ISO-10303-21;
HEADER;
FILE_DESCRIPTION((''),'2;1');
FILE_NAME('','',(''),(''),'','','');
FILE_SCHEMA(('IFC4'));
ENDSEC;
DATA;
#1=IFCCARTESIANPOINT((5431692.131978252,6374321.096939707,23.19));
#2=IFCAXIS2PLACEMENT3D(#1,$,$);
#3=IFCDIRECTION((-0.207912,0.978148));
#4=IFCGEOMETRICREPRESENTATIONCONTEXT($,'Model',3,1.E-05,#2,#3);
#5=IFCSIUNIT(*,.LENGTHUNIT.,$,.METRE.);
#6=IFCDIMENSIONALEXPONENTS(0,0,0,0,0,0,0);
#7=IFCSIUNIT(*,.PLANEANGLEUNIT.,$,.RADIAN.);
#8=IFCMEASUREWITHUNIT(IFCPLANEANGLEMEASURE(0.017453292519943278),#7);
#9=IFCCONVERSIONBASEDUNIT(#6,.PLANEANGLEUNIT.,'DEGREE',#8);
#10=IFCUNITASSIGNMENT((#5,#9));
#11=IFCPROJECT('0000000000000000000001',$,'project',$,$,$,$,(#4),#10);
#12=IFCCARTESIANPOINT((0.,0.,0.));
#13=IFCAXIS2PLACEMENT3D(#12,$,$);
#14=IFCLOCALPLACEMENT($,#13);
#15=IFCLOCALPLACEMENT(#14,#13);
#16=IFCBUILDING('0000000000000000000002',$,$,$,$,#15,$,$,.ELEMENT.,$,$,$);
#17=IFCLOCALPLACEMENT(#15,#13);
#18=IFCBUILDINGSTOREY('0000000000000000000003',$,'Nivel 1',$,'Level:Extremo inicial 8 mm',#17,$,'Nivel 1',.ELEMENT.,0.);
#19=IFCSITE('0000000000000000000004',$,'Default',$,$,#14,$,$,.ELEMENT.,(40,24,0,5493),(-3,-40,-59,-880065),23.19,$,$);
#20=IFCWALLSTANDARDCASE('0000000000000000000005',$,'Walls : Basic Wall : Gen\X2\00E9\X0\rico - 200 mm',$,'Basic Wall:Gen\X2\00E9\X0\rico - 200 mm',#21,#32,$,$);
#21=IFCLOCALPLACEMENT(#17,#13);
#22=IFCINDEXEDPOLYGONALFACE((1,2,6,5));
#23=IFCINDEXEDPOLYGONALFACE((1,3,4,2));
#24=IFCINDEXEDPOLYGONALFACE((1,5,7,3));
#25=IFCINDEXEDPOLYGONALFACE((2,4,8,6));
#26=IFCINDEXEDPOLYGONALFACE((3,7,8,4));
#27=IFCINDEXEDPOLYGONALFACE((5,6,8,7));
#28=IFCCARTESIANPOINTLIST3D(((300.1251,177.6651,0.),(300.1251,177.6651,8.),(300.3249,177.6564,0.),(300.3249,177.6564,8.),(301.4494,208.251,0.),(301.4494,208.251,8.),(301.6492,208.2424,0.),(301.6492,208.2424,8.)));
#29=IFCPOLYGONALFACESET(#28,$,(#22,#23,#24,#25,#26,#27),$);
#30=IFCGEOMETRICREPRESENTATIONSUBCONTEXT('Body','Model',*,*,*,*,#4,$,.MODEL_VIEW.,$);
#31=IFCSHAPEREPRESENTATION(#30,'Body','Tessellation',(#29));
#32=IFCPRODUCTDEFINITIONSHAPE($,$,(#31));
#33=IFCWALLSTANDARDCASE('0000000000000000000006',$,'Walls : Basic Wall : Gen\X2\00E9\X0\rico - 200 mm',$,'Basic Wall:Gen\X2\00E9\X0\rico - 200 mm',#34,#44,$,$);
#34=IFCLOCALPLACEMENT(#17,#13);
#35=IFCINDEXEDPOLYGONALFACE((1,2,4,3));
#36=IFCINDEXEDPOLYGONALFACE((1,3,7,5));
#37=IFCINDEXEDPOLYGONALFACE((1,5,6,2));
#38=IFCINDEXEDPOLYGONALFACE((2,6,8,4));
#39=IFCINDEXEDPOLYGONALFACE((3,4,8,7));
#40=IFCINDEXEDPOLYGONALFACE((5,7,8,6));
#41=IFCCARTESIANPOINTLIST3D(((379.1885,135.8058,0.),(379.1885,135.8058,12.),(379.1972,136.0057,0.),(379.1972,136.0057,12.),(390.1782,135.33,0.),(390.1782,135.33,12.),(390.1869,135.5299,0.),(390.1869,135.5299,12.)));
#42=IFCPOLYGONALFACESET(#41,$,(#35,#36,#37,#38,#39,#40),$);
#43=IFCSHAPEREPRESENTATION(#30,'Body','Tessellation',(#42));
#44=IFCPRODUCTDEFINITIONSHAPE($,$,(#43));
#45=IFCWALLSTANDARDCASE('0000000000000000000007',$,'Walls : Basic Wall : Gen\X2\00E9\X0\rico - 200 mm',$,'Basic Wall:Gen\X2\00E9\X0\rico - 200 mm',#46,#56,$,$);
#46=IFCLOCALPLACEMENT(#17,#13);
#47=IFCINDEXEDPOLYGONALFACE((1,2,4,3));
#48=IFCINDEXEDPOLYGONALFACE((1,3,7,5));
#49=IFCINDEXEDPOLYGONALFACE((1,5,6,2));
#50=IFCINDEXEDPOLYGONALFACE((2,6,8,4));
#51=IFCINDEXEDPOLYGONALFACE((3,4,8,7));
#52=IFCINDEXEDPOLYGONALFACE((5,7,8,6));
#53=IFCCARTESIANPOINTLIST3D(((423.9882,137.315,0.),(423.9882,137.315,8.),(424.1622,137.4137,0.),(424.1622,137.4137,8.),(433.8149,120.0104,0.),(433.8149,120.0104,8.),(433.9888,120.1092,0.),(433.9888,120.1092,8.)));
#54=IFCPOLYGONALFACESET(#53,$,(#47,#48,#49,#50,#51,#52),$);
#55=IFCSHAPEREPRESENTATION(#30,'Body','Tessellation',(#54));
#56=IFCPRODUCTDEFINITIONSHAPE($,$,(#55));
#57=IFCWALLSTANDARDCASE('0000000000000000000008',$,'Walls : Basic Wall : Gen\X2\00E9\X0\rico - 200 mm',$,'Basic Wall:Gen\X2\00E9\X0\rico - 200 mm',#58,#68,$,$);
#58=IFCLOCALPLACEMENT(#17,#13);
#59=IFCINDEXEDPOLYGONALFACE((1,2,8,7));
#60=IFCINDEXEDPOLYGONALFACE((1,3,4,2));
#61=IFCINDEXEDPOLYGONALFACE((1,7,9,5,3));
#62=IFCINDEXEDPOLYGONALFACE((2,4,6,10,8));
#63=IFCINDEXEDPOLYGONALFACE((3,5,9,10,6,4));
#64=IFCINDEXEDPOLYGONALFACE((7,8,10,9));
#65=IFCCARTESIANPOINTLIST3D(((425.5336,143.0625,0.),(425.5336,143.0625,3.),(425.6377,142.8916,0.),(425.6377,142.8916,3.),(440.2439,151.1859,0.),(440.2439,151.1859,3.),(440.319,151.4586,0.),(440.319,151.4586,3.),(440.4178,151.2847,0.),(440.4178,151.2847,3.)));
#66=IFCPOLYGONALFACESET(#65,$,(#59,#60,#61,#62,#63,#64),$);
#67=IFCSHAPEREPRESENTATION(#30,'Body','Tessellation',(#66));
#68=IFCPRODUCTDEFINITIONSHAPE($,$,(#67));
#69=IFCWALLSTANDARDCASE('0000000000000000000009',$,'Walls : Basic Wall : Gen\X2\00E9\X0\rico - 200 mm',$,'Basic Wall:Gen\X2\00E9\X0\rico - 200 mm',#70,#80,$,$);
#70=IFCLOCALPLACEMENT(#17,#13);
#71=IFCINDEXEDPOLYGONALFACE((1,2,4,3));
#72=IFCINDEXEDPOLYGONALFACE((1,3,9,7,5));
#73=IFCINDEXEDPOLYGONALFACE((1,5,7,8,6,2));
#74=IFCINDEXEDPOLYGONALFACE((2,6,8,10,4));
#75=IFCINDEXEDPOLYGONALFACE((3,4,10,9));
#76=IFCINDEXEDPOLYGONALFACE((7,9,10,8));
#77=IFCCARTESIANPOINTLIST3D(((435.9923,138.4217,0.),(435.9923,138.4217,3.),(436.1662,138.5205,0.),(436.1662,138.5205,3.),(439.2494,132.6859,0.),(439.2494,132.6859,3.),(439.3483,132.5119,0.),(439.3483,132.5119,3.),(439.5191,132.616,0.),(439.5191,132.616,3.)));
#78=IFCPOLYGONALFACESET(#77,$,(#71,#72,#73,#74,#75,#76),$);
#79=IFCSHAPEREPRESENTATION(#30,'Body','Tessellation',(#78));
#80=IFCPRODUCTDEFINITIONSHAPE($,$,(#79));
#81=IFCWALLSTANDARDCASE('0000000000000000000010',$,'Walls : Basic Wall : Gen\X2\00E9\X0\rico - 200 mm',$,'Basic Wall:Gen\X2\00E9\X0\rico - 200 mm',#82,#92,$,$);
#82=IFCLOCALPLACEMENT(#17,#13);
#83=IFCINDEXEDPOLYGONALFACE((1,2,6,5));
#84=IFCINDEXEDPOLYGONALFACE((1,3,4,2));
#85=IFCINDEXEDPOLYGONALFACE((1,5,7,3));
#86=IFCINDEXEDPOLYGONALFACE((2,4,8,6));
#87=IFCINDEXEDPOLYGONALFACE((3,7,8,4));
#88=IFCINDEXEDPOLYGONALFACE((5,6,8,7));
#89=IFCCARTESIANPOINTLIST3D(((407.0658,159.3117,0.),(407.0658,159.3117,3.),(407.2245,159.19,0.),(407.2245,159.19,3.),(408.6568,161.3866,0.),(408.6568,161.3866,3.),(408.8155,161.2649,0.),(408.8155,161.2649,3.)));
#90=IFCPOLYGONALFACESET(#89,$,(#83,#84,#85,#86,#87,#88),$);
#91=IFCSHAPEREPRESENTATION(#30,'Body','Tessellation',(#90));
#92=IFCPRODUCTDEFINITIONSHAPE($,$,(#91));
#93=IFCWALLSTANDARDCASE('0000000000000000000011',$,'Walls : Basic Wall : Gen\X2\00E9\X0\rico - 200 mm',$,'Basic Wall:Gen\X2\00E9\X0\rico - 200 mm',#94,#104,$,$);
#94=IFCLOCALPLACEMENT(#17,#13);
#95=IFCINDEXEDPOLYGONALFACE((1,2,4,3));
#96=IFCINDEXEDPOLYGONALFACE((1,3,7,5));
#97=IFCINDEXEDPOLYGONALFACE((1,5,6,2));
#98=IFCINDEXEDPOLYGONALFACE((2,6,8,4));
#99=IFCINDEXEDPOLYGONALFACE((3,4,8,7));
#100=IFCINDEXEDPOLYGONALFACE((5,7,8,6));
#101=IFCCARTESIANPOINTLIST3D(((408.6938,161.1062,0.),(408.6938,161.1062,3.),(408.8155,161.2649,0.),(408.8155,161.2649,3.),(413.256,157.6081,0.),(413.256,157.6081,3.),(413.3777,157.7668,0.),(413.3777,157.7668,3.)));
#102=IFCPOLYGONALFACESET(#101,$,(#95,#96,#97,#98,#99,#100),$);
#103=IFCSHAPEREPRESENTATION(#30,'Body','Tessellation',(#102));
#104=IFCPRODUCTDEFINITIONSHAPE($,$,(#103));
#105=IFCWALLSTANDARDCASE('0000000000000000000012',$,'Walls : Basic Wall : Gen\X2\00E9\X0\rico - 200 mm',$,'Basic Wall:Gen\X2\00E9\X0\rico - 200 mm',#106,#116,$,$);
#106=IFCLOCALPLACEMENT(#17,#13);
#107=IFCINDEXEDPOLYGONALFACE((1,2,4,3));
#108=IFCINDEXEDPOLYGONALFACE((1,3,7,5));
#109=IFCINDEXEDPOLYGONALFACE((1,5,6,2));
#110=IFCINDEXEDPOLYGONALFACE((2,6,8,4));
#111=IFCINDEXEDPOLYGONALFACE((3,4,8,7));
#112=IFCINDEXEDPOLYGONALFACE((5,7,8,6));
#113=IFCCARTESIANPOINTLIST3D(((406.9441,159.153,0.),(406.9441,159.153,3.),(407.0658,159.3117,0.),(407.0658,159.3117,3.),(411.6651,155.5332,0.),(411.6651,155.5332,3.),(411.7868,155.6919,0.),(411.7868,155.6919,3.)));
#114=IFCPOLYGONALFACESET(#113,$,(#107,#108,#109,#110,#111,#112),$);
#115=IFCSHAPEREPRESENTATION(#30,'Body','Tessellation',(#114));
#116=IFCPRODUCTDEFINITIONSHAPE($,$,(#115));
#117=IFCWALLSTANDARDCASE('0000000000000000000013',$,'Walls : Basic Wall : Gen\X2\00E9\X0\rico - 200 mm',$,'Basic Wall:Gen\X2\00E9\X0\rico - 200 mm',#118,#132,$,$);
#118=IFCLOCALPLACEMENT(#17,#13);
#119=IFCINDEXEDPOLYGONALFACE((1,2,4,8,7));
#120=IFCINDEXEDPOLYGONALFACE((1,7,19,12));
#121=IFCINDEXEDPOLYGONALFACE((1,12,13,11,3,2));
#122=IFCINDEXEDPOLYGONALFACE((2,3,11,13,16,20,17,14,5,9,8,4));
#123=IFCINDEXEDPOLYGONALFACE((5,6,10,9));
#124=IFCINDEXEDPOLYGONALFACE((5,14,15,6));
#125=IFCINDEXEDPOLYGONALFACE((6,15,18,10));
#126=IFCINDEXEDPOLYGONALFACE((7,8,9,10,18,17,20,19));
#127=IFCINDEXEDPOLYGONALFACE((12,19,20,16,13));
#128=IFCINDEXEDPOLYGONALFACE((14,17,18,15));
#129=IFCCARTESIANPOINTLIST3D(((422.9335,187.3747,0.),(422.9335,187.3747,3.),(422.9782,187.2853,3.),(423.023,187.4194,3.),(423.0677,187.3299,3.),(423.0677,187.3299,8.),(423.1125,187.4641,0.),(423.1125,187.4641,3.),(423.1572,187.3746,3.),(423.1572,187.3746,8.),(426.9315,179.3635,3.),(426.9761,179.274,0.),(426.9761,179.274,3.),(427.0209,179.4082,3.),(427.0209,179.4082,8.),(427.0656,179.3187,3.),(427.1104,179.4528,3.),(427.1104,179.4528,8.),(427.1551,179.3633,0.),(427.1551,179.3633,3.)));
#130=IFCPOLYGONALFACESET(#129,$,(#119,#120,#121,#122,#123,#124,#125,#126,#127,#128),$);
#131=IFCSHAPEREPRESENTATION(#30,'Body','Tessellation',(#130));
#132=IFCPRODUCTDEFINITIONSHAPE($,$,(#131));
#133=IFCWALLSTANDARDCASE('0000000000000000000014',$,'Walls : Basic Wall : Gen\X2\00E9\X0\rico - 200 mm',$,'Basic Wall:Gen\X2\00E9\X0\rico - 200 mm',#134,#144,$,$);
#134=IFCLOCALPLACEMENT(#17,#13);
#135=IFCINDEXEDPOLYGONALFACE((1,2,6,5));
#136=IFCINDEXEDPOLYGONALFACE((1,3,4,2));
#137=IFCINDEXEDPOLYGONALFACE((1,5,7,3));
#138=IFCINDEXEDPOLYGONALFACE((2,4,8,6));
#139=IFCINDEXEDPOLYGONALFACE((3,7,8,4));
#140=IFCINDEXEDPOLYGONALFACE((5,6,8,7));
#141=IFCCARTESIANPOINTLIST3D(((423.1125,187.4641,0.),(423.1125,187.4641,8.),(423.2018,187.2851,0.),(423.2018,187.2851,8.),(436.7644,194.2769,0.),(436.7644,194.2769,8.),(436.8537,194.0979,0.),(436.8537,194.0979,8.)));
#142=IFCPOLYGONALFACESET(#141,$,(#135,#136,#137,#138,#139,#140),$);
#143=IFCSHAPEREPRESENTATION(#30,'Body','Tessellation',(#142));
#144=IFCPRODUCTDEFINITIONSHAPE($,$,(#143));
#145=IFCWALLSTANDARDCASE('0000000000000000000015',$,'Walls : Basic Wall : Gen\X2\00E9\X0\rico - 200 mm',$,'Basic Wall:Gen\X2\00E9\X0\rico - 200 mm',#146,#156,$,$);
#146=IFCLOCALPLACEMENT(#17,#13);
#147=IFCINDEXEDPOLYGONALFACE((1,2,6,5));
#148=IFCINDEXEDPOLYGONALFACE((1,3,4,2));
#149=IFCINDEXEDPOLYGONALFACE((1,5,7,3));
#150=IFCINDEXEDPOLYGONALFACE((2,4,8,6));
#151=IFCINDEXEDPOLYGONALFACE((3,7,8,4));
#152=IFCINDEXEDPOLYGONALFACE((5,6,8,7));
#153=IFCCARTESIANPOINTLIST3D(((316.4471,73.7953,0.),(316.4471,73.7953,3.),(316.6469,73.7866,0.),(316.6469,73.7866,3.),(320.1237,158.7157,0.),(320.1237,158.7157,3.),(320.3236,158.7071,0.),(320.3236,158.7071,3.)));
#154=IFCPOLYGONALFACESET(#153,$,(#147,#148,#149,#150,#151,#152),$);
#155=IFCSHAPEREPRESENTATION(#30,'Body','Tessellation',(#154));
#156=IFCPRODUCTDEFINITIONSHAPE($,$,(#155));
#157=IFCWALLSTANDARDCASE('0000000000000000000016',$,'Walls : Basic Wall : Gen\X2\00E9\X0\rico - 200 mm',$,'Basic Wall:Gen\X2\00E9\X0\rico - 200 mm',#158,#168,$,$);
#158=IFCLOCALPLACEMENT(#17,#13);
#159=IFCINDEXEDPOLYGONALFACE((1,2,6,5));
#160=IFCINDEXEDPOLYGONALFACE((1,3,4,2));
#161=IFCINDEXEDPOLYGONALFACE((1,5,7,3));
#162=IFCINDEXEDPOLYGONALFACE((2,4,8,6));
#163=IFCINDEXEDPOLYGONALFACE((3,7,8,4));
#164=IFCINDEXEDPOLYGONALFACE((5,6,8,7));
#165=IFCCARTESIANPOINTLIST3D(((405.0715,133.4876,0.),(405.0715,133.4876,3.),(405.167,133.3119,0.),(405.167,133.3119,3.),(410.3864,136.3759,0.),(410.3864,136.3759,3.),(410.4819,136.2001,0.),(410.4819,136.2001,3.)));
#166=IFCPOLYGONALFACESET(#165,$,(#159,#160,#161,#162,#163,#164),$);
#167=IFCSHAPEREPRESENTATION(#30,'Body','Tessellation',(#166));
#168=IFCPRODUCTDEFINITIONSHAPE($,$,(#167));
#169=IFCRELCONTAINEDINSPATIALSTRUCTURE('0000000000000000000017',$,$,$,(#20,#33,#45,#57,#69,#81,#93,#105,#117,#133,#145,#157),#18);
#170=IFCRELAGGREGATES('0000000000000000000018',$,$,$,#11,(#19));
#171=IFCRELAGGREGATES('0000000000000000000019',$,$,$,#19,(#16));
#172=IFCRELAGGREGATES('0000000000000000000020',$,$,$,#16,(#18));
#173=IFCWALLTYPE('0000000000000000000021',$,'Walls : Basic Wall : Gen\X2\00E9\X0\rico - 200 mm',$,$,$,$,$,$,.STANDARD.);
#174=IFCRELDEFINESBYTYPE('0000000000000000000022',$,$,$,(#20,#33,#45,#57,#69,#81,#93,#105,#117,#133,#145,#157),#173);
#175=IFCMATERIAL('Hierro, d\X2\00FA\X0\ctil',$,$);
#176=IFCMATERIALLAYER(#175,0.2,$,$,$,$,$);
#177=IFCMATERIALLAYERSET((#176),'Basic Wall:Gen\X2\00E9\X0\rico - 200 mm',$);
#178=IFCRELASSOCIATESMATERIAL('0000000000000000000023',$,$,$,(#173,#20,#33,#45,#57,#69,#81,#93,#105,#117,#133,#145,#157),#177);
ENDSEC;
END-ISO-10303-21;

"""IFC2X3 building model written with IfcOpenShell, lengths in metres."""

from ifc_helpers import new_model, entity, si_unit, converted_unit, direction, frame, frame_2d, origin, place, context, subcontext, project, spatial, polyline, rectangle, outline, extrude, clip, bounded_halfspace, material, layer, layer_set, layer_usage, type_object, element, save


model = new_model("IFC2X3")

# Units and contexts
model_context = context("Model", 3, precision=1e-05, world=frame((5431692.131978252, 6374321.096939707, 23.19)), true_north=direction((-0.207912, 0.978148)))
body_context = subcontext(model_context, "Body", "Model", "MODEL_VIEW")
ifc_project = project(units=[si_unit("LENGTHUNIT", "METRE"), converted_unit("PLANEANGLEUNIT", "DEGREE", entity("IfcPlaneAngleMeasure", 0.017453292519943278), si_unit("PLANEANGLEUNIT", "RADIAN"), dimensions=[0, 0, 0, 0, 0, 0, 0])], contexts=[model_context])

# Site, building, storey
site_placement = place(None, origin())
site = spatial("IfcSite", under=ifc_project, at=site_placement, Name="Default", CompositionType="ELEMENT", RefLatitude=(40, 24, 0, 5493), RefLongitude=(-3, -40, -59, -880065), RefElevation=23.19)
building_placement = place(site_placement, origin())
building = spatial("IfcBuilding", under=site, at=building_placement, CompositionType="ELEMENT")
storey_placement = place(building_placement, origin())
storey = spatial("IfcBuildingStorey", under=building, at=storey_placement, Name="Nivel 1", ObjectType="Level:Extremo inicial 8 mm", LongName="Nivel 1", CompositionType="ELEMENT", Elevation=0.0)

# Walls
ifc_material_1 = material(Name="Hierro, dúctil")
ifc_layer_1 = layer(ifc_material_1, 0.2)
ifc_layer_set_1 = layer_set([ifc_layer_1], Name="Basic Wall:Genérico - 200 mm")
wall_type = type_object("IfcWallType", Name="Walls : Basic Wall : Genérico - 200 mm", PredefinedType="STANDARD", material=ifc_layer_set_1)
ifc_layer_usage_1 = layer_usage(ifc_layer_set_1, "AXIS2", "NEGATIVE", 0.1)
wall_1_placement = place(storey_placement, frame((300.225, 177.6607, 0.0), z_axis=(0.0, 0.0, 1.0), x_axis=(0.043255, 0.999064, 0.0)))
element("IfcWallStandardCase", 1, at=wall_1_placement, inside=storey, type_object=wall_type, material=ifc_layer_usage_1, Name="Walls : Basic Wall : Genérico - 200 mm", ObjectType="Basic Wall:Genérico - 200 mm", context=body_context, shape_type="SweptSolid", body=[
    extrude(rectangle(XDim=30.6146, YDim=0.2, at=frame_2d((15.3073, 0.0), x_axis=(-1.0, 0.0))), origin(), (0.0, 0.0, 1.0), 8.0),
])
ifc_layer_usage_2 = layer_usage(ifc_layer_set_1, "AXIS2", "NEGATIVE", 0.1)
wall_2_placement = place(storey_placement, frame((390.1826, 135.4299, 0.0), z_axis=(0.0, 0.0, 1.0), x_axis=(-0.999064, 0.043255, 0.0)))
element("IfcWallStandardCase", 2, at=wall_2_placement, inside=storey, type_object=wall_type, material=ifc_layer_usage_2, Name="Walls : Basic Wall : Genérico - 200 mm", ObjectType="Basic Wall:Genérico - 200 mm", context=body_context, shape_type="Clipping", body=[
    clip(extrude(rectangle(XDim=11.0, YDim=0.2, at=frame_2d((5.5, 0.0), x_axis=(-1.0, 0.0))), origin(), (0.0, 0.0, 1.0), 12.0), bounded_halfspace(frame((0.0, -0.1, 12.0), z_axis=(0.0, 0.0, 1.0), x_axis=(-0.999064, -0.043255, 0.0)), False, frame((0.0, -0.1, 12.0)), polyline([(0.0, 0.0), (11.0, 0.0), (11.0, 0.2), (0.0, 0.2), (0.0, 0.0)]))),
])
ifc_layer_usage_3 = layer_usage(ifc_layer_set_1, "AXIS2", "NEGATIVE", 0.1)
wall_3_placement = place(storey_placement, frame((424.0752, 137.3644, 0.0), z_axis=(0.0, 0.0, 1.0), x_axis=(0.4938, -0.869576, 0.0)))
element("IfcWallStandardCase", 3, at=wall_3_placement, inside=storey, type_object=wall_type, material=ifc_layer_usage_3, Name="Walls : Basic Wall : Genérico - 200 mm", ObjectType="Basic Wall:Genérico - 200 mm", context=body_context, shape_type="SweptSolid", body=[
    extrude(rectangle(XDim=19.9, YDim=0.2, at=frame_2d((9.95, 0.0), x_axis=(-1.0, 0.0))), origin(), (0.0, 0.0, 1.0), 8.0),
])
ifc_layer_usage_4 = layer_usage(ifc_layer_set_1, "AXIS2", "NEGATIVE", 0.1)
wall_4_placement = place(storey_placement, frame((425.583, 142.9755, 0.0), z_axis=(0.0, 0.0, 1.0), x_axis=(0.869576, 0.4938, 0.0)))
element("IfcWallStandardCase", 4, at=wall_4_placement, inside=storey, type_object=wall_type, material=ifc_layer_usage_4, Name="Walls : Basic Wall : Genérico - 200 mm", ObjectType="Basic Wall:Genérico - 200 mm", context=body_context, shape_type="SweptSolid", body=[
    extrude(outline(polyline([(17.003, -0.1), (17.003, 0.1), (0.0, 0.1), (0.0061, -0.1), (16.803, -0.1), (17.003, -0.1)])), origin(), (0.0, 0.0, 1.0), 3.0),
])
ifc_layer_usage_5 = layer_usage(ifc_layer_set_1, "AXIS2", "NEGATIVE", 0.1)
wall_5_placement = place(storey_placement, frame((436.0793, 138.4711, 0.0), z_axis=(0.0, 0.0, 1.0), x_axis=(0.4938, -0.869576, 0.0)))
element("IfcWallStandardCase", 5, at=wall_5_placement, inside=storey, type_object=wall_type, material=ifc_layer_usage_5, Name="Walls : Basic Wall : Genérico - 200 mm", ObjectType="Basic Wall:Genérico - 200 mm", context=body_context, shape_type="SweptSolid", body=[
    extrude(outline(polyline([(6.7962, -0.1), (6.79, 0.1), (0.0, 0.1), (0.0, -0.1), (6.5961, -0.1), (6.7962, -0.1)])), origin(), (0.0, 0.0, 1.0), 3.0),
])
ifc_layer_usage_6 = layer_usage(ifc_layer_set_1, "AXIS2", "NEGATIVE", 0.1)
wall_6_placement = place(storey_placement, frame((407.1452, 159.2508, 0.0), z_axis=(0.0, 0.0, 1.0), x_axis=(0.608472, 0.793576, 0.0)))
element("IfcWallStandardCase", 6, at=wall_6_placement, inside=storey, type_object=wall_type, material=ifc_layer_usage_6, Name="Walls : Basic Wall : Genérico - 200 mm", ObjectType="Basic Wall:Genérico - 200 mm", context=body_context, shape_type="SweptSolid", body=[
    extrude(rectangle(XDim=2.6147, YDim=0.2, at=frame_2d((1.3073, 0.0), x_axis=(-1.0, 0.0))), origin(), (0.0, 0.0, 1.0), 3.0),
])
ifc_layer_usage_7 = layer_usage(ifc_layer_set_1, "AXIS2", "NEGATIVE", 0.1)
wall_7_placement = place(storey_placement, frame((408.7546, 161.1856, 0.0), z_axis=(0.0, 0.0, 1.0), x_axis=(0.793576, -0.608472, 0.0)))
element("IfcWallStandardCase", 7, at=wall_7_placement, inside=storey, type_object=wall_type, material=ifc_layer_usage_7, Name="Walls : Basic Wall : Genérico - 200 mm", ObjectType="Basic Wall:Genérico - 200 mm", context=body_context, shape_type="SweptSolid", body=[
    extrude(rectangle(XDim=5.749, YDim=0.2, at=frame_2d((2.8745, 0.0), x_axis=(-1.0, 0.0))), origin(), (0.0, 0.0, 1.0), 3.0),
])
ifc_layer_usage_8 = layer_usage(ifc_layer_set_1, "AXIS2", "NEGATIVE", 0.1)
wall_8_placement = place(storey_placement, frame((411.7259, 155.6125, 0.0), z_axis=(0.0, 0.0, 1.0), x_axis=(-0.793576, 0.608472, 0.0)))
element("IfcWallStandardCase", 8, at=wall_8_placement, inside=storey, type_object=wall_type, material=ifc_layer_usage_8, Name="Walls : Basic Wall : Genérico - 200 mm", ObjectType="Basic Wall:Genérico - 200 mm", context=body_context, shape_type="SweptSolid", body=[
    extrude(rectangle(XDim=5.949, YDim=0.2, at=frame_2d((2.9745, 0.0), x_axis=(-1.0, 0.0))), origin(), (0.0, 0.0, 1.0), 3.0),
])
ifc_layer_usage_9 = layer_usage(ifc_layer_set_1, "AXIS2", "NEGATIVE", 0.1)
wall_9_placement = place(storey_placement, frame((427.0656, 179.3187, 0.0), z_axis=(0.0, 0.0, 1.0), x_axis=(-0.446525, 0.894771, 0.0)))
element("IfcWallStandardCase", 9, at=wall_9_placement, inside=storey, type_object=wall_type, material=ifc_layer_usage_9, Name="Walls : Basic Wall : Genérico - 200 mm", ObjectType="Basic Wall:Genérico - 200 mm", context=body_context, shape_type="Clipping", body=[
    clip(clip(clip(clip(clip(clip(extrude(rectangle(XDim=9.0534, YDim=0.2, at=frame_2d((4.5267, 0.0), x_axis=(-1.0, 0.0))), origin(), (0.0, 0.0, 1.0), 8.0), bounded_halfspace(frame((0.1, -0.1, 8.0), z_axis=(0.0, 0.0, 1.0), x_axis=(-0.446525, -0.894771, 0.0)), False, frame((0.1, -0.1, 8.0)), polyline([(0.0, 0.0), (0.1, 0.0), (8.7534, 0.0), (8.8534, 0.0), (8.8534, 0.1), (0.0, 0.1), (0.0, 0.0)]))), bounded_halfspace(frame((8.9534, -0.1, 3.0), z_axis=(0.0, 0.0, 1.0), x_axis=(0.0, 1.0, 0.0)), False, frame((8.9534, -0.1, 3.0)), polyline([(0.0, 0.0), (0.1, 0.0), (0.1, 0.1), (0.0, 0.1), (0.0, 0.0)]))), bounded_halfspace(frame((9.0534, 0.0, 3.0), z_axis=(0.0, 0.0, 1.0), x_axis=(0.0, 1.0, 0.0)), False, frame((9.0534, 0.0, 3.0)), polyline([(0.0, 0.0), (0.0, 0.1), (-0.1, 0.1), (-0.1, 0.0), (0.0, 0.0)]))), bounded_halfspace(frame((0.0, -0.1, 3.0), z_axis=(0.0, 0.0, 1.0), x_axis=(0.0, 1.0, 0.0)), False, frame((0.0, -0.1, 3.0)), polyline([(0.0, 0.0), (0.1, 0.0), (0.1, 0.1), (0.0, 0.1), (0.0, 0.0)]))), bounded_halfspace(frame((8.9534, 0.1, 3.0), z_axis=(0.0, 0.0, 1.0), x_axis=(0.0, 1.0, 0.0)), False, frame((8.9534, 0.1, 3.0)), polyline([(0.0, 0.0), (-8.8534, 0.0), (-8.8534, -0.1), (0.0, -0.1), (0.0, 0.0)]))), bounded_halfspace(frame((0.1, 0.1, 3.0), z_axis=(0.0, 0.0, 1.0), x_axis=(0.0, 1.0, 0.0)), False, frame((0.1, 0.1, 3.0)), polyline([(0.0, 0.0), (-0.1, 0.0), (-0.1, -0.1), (0.0, -0.1), (0.0, 0.0)]))),
])
ifc_layer_usage_10 = layer_usage(ifc_layer_set_1, "AXIS2", "NEGATIVE", 0.1)
wall_10_placement = place(storey_placement, frame((423.1572, 187.3746, 0.0), z_axis=(0.0, 0.0, 1.0), x_axis=(0.894771, 0.446525, 0.0)))
element("IfcWallStandardCase", 10, at=wall_10_placement, inside=storey, type_object=wall_type, material=ifc_layer_usage_10, Name="Walls : Basic Wall : Genérico - 200 mm", ObjectType="Basic Wall:Genérico - 200 mm", context=body_context, shape_type="Clipping", body=[
    clip(extrude(rectangle(XDim=15.2575, YDim=0.2, at=frame_2d((7.6287, 0.0), x_axis=(-1.0, 0.0))), origin(), (0.0, 0.0, 1.0), 8.0), bounded_halfspace(frame((0.0, -0.1, 8.0), z_axis=(0.0, 0.0, 1.0), x_axis=(0.894771, -0.446525, 0.0)), False, frame((0.0, -0.1, 8.0)), polyline([(0.0, 0.0), (5.0575, 0.0), (5.0575, 0.1), (0.0, 0.1), (0.0, 0.0)]))),
])
ifc_layer_usage_11 = layer_usage(ifc_layer_set_1, "AXIS2", "NEGATIVE", 0.1)
wall_11_placement = place(storey_placement, frame((320.2237, 158.7114, 0.0), z_axis=(0.0, 0.0, 1.0), x_axis=(-0.043255, -0.999064, 0.0)))
element("IfcWallStandardCase", 11, at=wall_11_placement, inside=storey, type_object=wall_type, material=ifc_layer_usage_11, Name="Walls : Basic Wall : Genérico - 200 mm", ObjectType="Basic Wall:Genérico - 200 mm", context=body_context, shape_type="SweptSolid", body=[
    extrude(rectangle(XDim=85.0, YDim=0.2, at=frame_2d((42.5, 0.0), x_axis=(-1.0, 0.0))), origin(), (0.0, 0.0, 1.0), 3.0),
])
ifc_layer_usage_12 = layer_usage(ifc_layer_set_1, "AXIS2", "NEGATIVE", 0.1)
wall_12_placement = place(storey_placement, frame((410.4341, 136.288, 0.0), z_axis=(0.0, 0.0, 1.0), x_axis=(-0.878643, -0.47748, 0.0)))
element("IfcWallStandardCase", 12, at=wall_12_placement, inside=storey, type_object=wall_type, material=ifc_layer_usage_12, Name="Walls : Basic Wall : Genérico - 200 mm", ObjectType="Basic Wall:Genérico - 200 mm", context=body_context, shape_type="SweptSolid", body=[
    extrude(rectangle(XDim=6.049, YDim=0.2, at=frame_2d((3.0245, 0.0), x_axis=(-1.0, 0.0))), origin(), (0.0, 0.0, 1.0), 3.0),
])

save(model, "model.ifc")
